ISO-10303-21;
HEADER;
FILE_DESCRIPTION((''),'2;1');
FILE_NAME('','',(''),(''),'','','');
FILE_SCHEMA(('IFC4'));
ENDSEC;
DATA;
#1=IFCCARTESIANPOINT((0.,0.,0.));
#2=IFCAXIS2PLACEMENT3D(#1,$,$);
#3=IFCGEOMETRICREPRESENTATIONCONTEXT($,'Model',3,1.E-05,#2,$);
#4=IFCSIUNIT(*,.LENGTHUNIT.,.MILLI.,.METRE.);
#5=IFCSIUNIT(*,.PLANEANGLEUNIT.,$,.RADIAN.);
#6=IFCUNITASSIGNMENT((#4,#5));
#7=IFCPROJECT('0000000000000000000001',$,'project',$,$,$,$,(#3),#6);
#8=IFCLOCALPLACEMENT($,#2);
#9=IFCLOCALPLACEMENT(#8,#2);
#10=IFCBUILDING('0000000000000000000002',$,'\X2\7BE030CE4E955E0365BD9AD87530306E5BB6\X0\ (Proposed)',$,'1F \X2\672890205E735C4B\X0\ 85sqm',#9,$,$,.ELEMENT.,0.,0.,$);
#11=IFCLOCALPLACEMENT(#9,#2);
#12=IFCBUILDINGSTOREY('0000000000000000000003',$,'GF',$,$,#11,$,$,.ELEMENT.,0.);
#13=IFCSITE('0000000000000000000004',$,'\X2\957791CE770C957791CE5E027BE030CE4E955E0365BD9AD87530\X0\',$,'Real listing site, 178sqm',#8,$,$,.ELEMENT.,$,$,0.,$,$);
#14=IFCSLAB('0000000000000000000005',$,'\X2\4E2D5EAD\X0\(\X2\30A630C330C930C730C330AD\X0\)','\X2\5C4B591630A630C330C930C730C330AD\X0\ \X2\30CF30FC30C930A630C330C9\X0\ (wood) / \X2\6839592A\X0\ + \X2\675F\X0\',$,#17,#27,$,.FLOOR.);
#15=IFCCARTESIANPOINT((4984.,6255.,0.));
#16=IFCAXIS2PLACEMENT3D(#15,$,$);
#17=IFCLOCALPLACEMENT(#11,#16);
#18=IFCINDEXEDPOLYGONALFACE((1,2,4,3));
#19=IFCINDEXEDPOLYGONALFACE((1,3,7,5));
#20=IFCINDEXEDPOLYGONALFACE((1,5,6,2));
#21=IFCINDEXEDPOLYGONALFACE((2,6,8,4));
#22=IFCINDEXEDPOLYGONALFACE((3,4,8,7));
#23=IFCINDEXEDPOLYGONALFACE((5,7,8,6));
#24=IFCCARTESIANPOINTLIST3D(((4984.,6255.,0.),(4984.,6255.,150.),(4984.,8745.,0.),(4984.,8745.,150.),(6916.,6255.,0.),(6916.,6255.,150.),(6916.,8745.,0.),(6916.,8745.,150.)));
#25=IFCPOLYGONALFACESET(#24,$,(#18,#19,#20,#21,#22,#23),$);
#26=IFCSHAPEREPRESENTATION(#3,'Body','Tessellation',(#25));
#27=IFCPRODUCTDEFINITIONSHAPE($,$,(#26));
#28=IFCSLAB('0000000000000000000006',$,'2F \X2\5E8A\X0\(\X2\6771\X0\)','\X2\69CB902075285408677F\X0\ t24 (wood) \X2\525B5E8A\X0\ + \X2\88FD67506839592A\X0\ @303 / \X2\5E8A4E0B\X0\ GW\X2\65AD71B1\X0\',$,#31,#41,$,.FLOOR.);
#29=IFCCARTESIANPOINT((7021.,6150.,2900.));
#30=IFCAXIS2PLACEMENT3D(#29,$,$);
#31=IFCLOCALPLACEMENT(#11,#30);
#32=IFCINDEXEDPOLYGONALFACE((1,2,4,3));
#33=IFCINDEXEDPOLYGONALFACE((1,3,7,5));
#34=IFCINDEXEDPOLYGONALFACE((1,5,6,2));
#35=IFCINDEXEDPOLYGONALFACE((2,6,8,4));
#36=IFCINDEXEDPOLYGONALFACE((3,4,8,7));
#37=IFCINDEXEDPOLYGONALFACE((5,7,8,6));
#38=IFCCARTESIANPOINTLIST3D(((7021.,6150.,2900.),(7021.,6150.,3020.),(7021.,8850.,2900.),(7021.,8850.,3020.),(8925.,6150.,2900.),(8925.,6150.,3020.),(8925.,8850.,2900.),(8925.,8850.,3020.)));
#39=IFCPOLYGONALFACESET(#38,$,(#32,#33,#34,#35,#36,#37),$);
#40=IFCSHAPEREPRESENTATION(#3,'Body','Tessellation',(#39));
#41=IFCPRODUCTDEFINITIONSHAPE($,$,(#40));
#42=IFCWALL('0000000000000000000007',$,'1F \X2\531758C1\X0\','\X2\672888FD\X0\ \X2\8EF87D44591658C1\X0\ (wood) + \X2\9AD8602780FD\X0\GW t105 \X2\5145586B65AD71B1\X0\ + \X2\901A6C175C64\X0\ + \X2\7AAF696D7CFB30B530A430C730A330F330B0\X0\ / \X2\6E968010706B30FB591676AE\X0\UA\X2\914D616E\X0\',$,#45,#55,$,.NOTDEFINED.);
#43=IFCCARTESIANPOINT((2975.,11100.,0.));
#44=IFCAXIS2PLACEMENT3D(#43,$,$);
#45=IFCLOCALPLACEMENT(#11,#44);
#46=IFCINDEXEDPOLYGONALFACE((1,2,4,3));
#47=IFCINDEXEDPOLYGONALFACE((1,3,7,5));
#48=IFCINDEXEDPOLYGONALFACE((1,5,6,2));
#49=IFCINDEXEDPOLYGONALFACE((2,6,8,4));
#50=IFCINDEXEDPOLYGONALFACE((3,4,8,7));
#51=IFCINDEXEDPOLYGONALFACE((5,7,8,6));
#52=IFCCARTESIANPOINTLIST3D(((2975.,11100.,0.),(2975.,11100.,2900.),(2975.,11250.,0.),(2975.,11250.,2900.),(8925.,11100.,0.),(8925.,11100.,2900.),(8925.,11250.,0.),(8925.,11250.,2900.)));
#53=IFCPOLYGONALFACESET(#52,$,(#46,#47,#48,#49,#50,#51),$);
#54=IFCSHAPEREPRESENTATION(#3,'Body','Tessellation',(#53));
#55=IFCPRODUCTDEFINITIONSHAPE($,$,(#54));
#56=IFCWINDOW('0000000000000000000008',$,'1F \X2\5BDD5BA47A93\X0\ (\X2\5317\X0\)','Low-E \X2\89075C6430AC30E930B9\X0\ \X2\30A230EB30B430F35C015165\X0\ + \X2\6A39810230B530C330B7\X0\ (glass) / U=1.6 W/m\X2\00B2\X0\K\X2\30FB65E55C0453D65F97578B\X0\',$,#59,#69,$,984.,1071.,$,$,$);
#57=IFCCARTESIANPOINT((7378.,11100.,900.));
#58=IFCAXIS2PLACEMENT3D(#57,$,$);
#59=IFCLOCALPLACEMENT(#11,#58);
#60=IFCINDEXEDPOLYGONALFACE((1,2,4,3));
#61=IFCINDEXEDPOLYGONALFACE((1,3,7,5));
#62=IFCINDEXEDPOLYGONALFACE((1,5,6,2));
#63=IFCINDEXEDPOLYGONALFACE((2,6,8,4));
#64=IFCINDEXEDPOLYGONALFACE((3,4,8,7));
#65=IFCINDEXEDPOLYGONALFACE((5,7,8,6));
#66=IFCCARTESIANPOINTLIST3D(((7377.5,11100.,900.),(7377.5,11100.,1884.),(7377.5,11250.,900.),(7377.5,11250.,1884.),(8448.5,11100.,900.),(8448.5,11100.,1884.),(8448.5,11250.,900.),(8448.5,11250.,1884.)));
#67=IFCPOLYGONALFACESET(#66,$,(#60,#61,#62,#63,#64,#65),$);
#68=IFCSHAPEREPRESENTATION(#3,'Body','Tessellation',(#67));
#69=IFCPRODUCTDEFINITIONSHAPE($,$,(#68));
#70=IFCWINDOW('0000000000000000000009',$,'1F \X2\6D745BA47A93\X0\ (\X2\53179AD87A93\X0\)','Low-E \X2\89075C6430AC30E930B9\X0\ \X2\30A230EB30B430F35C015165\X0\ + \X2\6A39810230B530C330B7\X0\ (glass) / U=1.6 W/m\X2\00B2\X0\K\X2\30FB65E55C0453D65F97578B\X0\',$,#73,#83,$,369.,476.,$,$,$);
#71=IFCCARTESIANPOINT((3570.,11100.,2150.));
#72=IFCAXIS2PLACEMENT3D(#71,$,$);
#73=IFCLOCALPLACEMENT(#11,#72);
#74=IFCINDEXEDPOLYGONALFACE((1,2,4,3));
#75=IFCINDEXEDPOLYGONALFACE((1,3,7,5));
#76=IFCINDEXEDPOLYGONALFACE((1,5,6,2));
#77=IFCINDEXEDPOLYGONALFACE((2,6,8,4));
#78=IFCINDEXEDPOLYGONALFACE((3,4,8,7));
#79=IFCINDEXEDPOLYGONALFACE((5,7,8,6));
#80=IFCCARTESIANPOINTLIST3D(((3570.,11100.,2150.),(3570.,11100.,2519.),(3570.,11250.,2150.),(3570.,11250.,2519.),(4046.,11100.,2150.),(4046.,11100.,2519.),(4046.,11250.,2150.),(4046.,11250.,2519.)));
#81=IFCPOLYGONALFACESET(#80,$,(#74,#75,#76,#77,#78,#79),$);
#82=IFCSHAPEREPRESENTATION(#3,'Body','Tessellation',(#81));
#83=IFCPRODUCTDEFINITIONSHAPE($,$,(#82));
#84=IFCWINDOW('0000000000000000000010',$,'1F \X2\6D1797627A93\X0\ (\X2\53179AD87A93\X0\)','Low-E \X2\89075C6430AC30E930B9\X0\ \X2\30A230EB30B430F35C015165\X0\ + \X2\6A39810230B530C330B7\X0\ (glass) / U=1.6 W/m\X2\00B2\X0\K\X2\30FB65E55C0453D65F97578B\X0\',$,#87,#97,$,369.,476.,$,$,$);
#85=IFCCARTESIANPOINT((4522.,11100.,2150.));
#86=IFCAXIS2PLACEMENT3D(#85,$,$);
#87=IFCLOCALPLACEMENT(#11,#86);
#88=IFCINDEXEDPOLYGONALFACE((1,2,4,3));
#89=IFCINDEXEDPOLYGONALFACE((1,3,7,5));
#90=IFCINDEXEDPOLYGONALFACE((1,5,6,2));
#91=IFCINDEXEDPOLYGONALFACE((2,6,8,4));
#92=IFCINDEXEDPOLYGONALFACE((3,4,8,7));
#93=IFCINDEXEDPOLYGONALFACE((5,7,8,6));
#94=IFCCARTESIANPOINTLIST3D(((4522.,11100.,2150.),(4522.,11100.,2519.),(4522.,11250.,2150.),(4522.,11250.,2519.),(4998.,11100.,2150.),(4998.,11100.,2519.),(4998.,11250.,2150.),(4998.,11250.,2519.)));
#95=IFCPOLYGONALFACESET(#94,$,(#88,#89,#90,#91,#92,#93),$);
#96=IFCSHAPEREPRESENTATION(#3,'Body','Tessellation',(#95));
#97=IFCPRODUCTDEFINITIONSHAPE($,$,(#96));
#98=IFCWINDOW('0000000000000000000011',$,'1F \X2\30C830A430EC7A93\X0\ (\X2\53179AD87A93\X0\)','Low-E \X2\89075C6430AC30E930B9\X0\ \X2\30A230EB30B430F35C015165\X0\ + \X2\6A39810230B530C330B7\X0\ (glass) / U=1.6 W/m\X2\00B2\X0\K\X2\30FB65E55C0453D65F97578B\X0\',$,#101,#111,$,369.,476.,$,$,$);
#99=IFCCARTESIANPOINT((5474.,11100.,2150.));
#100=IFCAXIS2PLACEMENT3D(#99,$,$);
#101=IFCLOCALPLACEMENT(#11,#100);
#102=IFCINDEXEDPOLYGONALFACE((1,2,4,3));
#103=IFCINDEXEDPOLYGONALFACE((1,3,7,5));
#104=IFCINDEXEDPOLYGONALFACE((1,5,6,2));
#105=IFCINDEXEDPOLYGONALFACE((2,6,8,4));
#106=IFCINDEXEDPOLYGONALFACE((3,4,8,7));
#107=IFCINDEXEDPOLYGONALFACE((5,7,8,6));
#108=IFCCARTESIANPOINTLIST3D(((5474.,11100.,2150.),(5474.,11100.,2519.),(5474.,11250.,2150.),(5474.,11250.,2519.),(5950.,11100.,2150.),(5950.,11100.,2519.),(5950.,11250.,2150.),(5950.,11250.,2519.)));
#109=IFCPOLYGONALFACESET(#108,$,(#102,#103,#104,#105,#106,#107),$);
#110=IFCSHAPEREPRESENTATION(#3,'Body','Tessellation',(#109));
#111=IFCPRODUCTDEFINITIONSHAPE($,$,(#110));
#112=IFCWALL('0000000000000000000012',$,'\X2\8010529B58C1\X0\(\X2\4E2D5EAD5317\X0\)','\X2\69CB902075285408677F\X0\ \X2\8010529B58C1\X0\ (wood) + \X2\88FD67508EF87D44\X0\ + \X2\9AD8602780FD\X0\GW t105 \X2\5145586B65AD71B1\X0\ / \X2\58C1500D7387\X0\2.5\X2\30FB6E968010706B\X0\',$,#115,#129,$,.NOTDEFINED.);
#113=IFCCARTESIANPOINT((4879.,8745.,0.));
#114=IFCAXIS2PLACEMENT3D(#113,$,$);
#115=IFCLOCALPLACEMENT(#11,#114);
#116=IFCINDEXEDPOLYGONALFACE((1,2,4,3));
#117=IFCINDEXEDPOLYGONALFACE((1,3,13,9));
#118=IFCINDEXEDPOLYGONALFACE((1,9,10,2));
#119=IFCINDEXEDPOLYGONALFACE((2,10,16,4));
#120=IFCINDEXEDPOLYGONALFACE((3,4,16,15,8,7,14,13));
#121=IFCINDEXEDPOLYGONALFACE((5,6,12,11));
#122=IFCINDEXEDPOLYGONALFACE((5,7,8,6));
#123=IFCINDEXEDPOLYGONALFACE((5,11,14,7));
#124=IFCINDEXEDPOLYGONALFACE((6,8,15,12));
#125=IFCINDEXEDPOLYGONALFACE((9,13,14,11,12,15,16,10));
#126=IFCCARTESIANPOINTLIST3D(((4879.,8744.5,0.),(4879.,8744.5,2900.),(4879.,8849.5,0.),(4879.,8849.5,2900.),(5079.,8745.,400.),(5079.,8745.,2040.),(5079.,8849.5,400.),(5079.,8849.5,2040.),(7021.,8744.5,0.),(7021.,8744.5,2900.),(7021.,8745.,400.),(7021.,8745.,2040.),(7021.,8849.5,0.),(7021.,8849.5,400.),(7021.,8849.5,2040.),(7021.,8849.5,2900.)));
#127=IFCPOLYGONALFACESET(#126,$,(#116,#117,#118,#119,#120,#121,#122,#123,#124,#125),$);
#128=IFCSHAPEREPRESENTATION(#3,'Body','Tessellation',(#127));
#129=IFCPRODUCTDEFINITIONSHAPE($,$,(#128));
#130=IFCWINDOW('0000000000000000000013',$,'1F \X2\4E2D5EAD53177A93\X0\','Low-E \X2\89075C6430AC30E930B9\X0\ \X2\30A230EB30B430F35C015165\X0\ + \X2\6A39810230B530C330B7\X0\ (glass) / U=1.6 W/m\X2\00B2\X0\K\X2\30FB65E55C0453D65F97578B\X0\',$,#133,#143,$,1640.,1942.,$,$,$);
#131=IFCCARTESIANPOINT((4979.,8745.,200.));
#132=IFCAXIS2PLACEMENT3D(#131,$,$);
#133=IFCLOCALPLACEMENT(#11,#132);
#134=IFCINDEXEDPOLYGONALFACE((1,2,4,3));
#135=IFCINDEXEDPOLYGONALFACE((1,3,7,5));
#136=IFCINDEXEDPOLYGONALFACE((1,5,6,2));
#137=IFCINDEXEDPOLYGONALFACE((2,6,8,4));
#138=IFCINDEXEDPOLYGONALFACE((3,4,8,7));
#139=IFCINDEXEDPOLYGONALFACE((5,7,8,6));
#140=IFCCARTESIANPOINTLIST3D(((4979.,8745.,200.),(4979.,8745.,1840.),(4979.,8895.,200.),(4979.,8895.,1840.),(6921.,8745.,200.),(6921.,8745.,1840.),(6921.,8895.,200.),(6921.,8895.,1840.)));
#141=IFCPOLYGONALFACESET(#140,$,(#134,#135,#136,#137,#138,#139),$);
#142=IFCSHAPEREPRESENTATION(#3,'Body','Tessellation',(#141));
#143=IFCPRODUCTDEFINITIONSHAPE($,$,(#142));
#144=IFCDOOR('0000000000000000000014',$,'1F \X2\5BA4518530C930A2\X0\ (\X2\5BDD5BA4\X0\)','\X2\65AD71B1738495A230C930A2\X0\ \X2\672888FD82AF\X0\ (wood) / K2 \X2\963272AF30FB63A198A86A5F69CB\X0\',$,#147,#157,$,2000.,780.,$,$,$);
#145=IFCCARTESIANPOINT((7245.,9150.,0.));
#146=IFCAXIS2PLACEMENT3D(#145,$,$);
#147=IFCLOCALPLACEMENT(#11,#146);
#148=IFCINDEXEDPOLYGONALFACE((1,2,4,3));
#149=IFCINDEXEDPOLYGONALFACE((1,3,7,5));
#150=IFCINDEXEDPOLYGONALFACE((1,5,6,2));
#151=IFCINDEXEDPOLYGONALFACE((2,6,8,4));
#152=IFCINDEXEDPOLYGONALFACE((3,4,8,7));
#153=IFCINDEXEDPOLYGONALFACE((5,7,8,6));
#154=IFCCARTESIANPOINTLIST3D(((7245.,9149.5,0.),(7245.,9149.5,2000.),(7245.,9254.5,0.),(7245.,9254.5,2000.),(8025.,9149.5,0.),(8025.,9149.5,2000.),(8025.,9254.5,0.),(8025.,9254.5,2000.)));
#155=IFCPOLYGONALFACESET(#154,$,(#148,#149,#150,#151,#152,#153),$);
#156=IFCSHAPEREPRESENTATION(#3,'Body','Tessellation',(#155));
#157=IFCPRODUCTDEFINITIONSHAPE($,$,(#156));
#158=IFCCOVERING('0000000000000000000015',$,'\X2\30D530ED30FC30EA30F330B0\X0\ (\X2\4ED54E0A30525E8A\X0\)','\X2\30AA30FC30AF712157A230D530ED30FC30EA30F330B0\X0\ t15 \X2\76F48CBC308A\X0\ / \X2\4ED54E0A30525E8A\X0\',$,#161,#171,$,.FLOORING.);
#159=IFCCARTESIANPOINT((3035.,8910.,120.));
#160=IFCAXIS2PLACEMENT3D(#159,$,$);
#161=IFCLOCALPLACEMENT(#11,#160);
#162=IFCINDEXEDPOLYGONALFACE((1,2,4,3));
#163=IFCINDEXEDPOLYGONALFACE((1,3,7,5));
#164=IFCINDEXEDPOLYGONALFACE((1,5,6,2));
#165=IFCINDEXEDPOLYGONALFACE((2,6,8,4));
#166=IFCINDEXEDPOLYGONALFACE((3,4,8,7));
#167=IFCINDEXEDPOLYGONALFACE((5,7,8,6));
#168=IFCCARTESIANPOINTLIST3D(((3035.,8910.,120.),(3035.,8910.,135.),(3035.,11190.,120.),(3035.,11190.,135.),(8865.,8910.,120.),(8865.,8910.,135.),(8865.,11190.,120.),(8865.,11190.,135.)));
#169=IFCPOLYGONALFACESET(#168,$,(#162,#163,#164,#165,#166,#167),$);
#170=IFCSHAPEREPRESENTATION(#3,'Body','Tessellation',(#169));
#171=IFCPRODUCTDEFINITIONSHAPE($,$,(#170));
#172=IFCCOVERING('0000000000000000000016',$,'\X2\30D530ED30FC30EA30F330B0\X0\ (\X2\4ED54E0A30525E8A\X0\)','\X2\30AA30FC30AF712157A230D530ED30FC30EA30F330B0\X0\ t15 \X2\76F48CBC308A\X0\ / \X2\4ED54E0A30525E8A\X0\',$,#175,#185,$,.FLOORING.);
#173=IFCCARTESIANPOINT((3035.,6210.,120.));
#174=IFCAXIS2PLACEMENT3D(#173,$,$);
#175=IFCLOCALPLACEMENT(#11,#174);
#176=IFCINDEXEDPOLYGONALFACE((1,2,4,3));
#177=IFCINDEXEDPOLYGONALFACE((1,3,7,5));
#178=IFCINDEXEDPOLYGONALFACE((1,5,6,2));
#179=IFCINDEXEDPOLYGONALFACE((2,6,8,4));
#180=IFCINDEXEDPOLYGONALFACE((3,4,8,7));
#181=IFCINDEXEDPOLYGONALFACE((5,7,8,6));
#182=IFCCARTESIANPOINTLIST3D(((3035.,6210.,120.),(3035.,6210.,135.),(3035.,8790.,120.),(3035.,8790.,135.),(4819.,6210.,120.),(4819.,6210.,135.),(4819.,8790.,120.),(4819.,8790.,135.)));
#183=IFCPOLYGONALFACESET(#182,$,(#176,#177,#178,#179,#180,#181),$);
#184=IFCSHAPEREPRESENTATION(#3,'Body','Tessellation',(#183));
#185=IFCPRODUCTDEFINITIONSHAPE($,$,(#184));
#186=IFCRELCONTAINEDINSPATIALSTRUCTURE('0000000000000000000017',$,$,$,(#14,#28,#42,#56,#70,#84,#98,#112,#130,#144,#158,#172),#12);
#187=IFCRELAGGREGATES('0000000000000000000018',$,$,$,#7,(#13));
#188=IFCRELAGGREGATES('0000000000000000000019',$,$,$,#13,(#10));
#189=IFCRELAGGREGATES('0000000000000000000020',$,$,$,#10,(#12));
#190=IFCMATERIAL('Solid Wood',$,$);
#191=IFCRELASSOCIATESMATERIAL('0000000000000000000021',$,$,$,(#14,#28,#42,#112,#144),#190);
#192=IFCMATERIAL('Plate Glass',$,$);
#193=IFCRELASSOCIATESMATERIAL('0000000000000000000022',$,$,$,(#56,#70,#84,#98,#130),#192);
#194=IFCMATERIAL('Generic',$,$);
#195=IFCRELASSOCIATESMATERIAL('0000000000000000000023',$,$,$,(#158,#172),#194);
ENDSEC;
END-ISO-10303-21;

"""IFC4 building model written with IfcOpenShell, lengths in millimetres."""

from ifc_helpers import new_model, si_unit, frame, frame_2d, origin, place, context, project, spatial, rectangle, extrude, material, element, fill, save


model = new_model("IFC4")

# Units and contexts
model_context = context("Model", 3, precision=1e-05, world=origin())
ifc_project = project(units=[si_unit("LENGTHUNIT", "METRE", prefix="MILLI"), si_unit("PLANEANGLEUNIT", "RADIAN")], contexts=[model_context])

# Site, building, storey
site_placement = place(None, origin())
site = spatial("IfcSite", under=ifc_project, at=site_placement, Name="長野県長野市篠ノ井布施高田", ObjectType="Real listing site, 178sqm", CompositionType="ELEMENT", RefElevation=0.0)
building_placement = place(site_placement, origin())
building = spatial("IfcBuilding", under=site, at=building_placement, Name="篠ノ井布施高田の家 (Proposed)", ObjectType="1F 木造平屋 85sqm", CompositionType="ELEMENT", ElevationOfRefHeight=0.0, ElevationOfTerrain=0.0)
storey_placement = place(building_placement, origin())
storey = spatial("IfcBuildingStorey", under=building, at=storey_placement, Name="GF", CompositionType="ELEMENT", Elevation=0.0)

# Slabs
ifc_material_1 = material(Name="Solid Wood")
slab_1_placement = place(storey_placement, frame((4984.0, 6255.0, 0.0)))
element("IfcSlab", 1, at=slab_1_placement, inside=storey, material=ifc_material_1, Name="中庭(ウッドデッキ)", Description="屋外ウッドデッキ ハードウッド (wood) / 根太 + 束", PredefinedType="FLOOR", context=model_context, shape_type="SweptSolid", body=[
    extrude(rectangle(XDim=1932.0, YDim=2490.0, at=frame_2d((966.0, 1245.0))), frame((4984.0, 6255.0, 0.0)), (0.0, 0.0, 1.0), 150.0),
])
slab_2_placement = place(storey_placement, frame((7021.0, 6150.0, 2900.0)))
element("IfcSlab", 2, at=slab_2_placement, inside=storey, material=ifc_material_1, Name="2F 床(東)", Description="構造用合板 t24 (wood) 剛床 + 製材根太 @303 / 床下 GW断熱", PredefinedType="FLOOR", context=model_context, shape_type="SweptSolid", body=[
    extrude(rectangle(XDim=1904.0, YDim=2700.0, at=frame_2d((952.0, 1350.0))), frame((7021.0, 6150.0, 2900.0)), (0.0, 0.0, 1.0), 120.0),
])

# Wall, openings, windows
wall_1_placement = place(storey_placement, frame((2975.0, 11100.0, 0.0)))
wall_1 = element("IfcWall", 3, at=wall_1_placement, inside=storey, material=ifc_material_1, Name="1F 北壁", Description="木製 軸組外壁 (wood) + 高性能GW t105 充填断熱 + 通気層 + 窯業系サイディング / 準耐火・外皮UA配慮", PredefinedType="NOTDEFINED", context=model_context, shape_type="SweptSolid", body=[
    extrude(rectangle(XDim=5950.0, YDim=150.0, at=frame_2d((2975.0, 75.0))), frame((2975.0, 11100.0, 0.0)), (0.0, 0.0, 1.0), 2900.0),
])
opening_1_placement = place(storey_placement, frame((7378.0, 11100.0, 900.0)))
opening_1 = element("IfcOpeningElement", 4, at=opening_1_placement, cuts=wall_1, PredefinedType="NOTDEFINED", context=model_context, shape_type="SweptSolid", body=[
    extrude(rectangle(XDim=1071.0, YDim=150.0, at=frame_2d((535.0, 75.0))), frame((7378.0, 11100.0, 900.0)), (0.0, 0.0, 1.0), 984.0),
])
opening_2_placement = place(storey_placement, frame((3570.0, 11100.0, 2150.0)))
opening_2 = element("IfcOpeningElement", 5, at=opening_2_placement, cuts=wall_1, PredefinedType="NOTDEFINED", context=model_context, shape_type="SweptSolid", body=[
    extrude(rectangle(XDim=476.0, YDim=150.0, at=frame_2d((238.0, 75.0))), frame((3570.0, 11100.0, 2150.0)), (0.0, 0.0, 1.0), 369.0),
])
opening_3_placement = place(storey_placement, frame((4522.0, 11100.0, 2150.0)))
opening_3 = element("IfcOpeningElement", 6, at=opening_3_placement, cuts=wall_1, PredefinedType="NOTDEFINED", context=model_context, shape_type="SweptSolid", body=[
    extrude(rectangle(XDim=476.0, YDim=150.0, at=frame_2d((238.0, 75.0))), frame((4522.0, 11100.0, 2150.0)), (0.0, 0.0, 1.0), 369.0),
])
opening_4_placement = place(storey_placement, frame((5474.0, 11100.0, 2150.0)))
opening_4 = element("IfcOpeningElement", 7, at=opening_4_placement, cuts=wall_1, PredefinedType="NOTDEFINED", context=model_context, shape_type="SweptSolid", body=[
    extrude(rectangle(XDim=476.0, YDim=150.0, at=frame_2d((238.0, 75.0))), frame((5474.0, 11100.0, 2150.0)), (0.0, 0.0, 1.0), 369.0),
])
ifc_material_2 = material(Name="Plate Glass")
window_1_placement = place(storey_placement, frame((7378.0, 11100.0, 900.0)))
window_1 = element("IfcWindow", 8, at=window_1_placement, inside=storey, material=ifc_material_2, Name="1F 寝室窓 (北)", Description="Low-E 複層ガラス アルゴン封入 + 樹脂サッシ (glass) / U=1.6 W/m²K・日射取得型", OverallHeight=984.0, OverallWidth=1071.0, context=model_context, shape_type="SweptSolid", body=[
    extrude(rectangle(XDim=1071.0, YDim=150.0, at=frame_2d((535.0, 75.0))), frame((7378.0, 11100.0, 900.0)), (0.0, 0.0, 1.0), 984.0),
])
fill(opening_1, window_1)
window_2_placement = place(storey_placement, frame((3570.0, 11100.0, 2150.0)))
window_2 = element("IfcWindow", 9, at=window_2_placement, inside=storey, material=ifc_material_2, Name="1F 浴室窓 (北高窓)", Description="Low-E 複層ガラス アルゴン封入 + 樹脂サッシ (glass) / U=1.6 W/m²K・日射取得型", OverallHeight=369.0, OverallWidth=476.0, context=model_context, shape_type="SweptSolid", body=[
    extrude(rectangle(XDim=476.0, YDim=150.0, at=frame_2d((238.0, 75.0))), frame((3570.0, 11100.0, 2150.0)), (0.0, 0.0, 1.0), 369.0),
])
fill(opening_2, window_2)
window_3_placement = place(storey_placement, frame((4522.0, 11100.0, 2150.0)))
window_3 = element("IfcWindow", 10, at=window_3_placement, inside=storey, material=ifc_material_2, Name="1F 洗面窓 (北高窓)", Description="Low-E 複層ガラス アルゴン封入 + 樹脂サッシ (glass) / U=1.6 W/m²K・日射取得型", OverallHeight=369.0, OverallWidth=476.0, context=model_context, shape_type="SweptSolid", body=[
    extrude(rectangle(XDim=476.0, YDim=150.0, at=frame_2d((238.0, 75.0))), frame((4522.0, 11100.0, 2150.0)), (0.0, 0.0, 1.0), 369.0),
])
fill(opening_3, window_3)
window_4_placement = place(storey_placement, frame((5474.0, 11100.0, 2150.0)))
window_4 = element("IfcWindow", 11, at=window_4_placement, inside=storey, material=ifc_material_2, Name="1F トイレ窓 (北高窓)", Description="Low-E 複層ガラス アルゴン封入 + 樹脂サッシ (glass) / U=1.6 W/m²K・日射取得型", OverallHeight=369.0, OverallWidth=476.0, context=model_context, shape_type="SweptSolid", body=[
    extrude(rectangle(XDim=476.0, YDim=150.0, at=frame_2d((238.0, 75.0))), frame((5474.0, 11100.0, 2150.0)), (0.0, 0.0, 1.0), 369.0),
])
fill(opening_4, window_4)

# Wall, opening, window
wall_2_placement = place(storey_placement, frame((4879.0, 8745.0, 0.0)))
wall_2 = element("IfcWall", 12, at=wall_2_placement, inside=storey, material=ifc_material_1, Name="耐力壁(中庭北)", Description="構造用合板 耐力壁 (wood) + 製材軸組 + 高性能GW t105 充填断熱 / 壁倍率2.5・準耐火", PredefinedType="NOTDEFINED", context=model_context, shape_type="SweptSolid", body=[
    extrude(rectangle(XDim=2142.0, YDim=105.0, at=frame_2d((1071.0, 52.0))), frame((4879.0, 8745.0, 0.0)), (0.0, 0.0, 1.0), 2900.0),
])
opening_5_placement = place(storey_placement, frame((4979.0, 8745.0, 200.0)))
opening_5 = element("IfcOpeningElement", 13, at=opening_5_placement, cuts=wall_2, PredefinedType="NOTDEFINED", context=model_context, shape_type="SweptSolid", body=[
    extrude(rectangle(XDim=1942.0, YDim=150.0, at=frame_2d((971.0, 75.0))), frame((4979.0, 8745.0, 200.0)), (0.0, 0.0, 1.0), 1640.0),
])
window_5_placement = place(storey_placement, frame((4979.0, 8745.0, 200.0)))
window_5 = element("IfcWindow", 14, at=window_5_placement, inside=storey, material=ifc_material_2, Name="1F 中庭北窓", Description="Low-E 複層ガラス アルゴン封入 + 樹脂サッシ (glass) / U=1.6 W/m²K・日射取得型", OverallHeight=1640.0, OverallWidth=1942.0, context=model_context, shape_type="SweptSolid", body=[
    extrude(rectangle(XDim=1942.0, YDim=150.0, at=frame_2d((971.0, 75.0))), frame((4979.0, 8745.0, 200.0)), (0.0, 0.0, 1.0), 1640.0),
])
fill(opening_5, window_5)

# Door
door_1_placement = place(storey_placement, frame((7245.0, 9150.0, 0.0)))
element("IfcDoor", 15, at=door_1_placement, inside=storey, material=ifc_material_1, Name="1F 室内ドア (寝室)", Description="断熱玄関ドア 木製芯 (wood) / K2 防犯・採風機構", OverallHeight=2000.0, OverallWidth=780.0, context=model_context, shape_type="SweptSolid", body=[
    extrude(rectangle(XDim=780.0, YDim=105.0, at=frame_2d((390.0, 52.0))), frame((7245.0, 9150.0, 0.0)), (0.0, 0.0, 1.0), 2000.0),
])

# Coverings
ifc_material_3 = material(Name="Generic")
covering_1_placement = place(storey_placement, frame((3035.0, 8910.0, 120.0)))
element("IfcCovering", 16, at=covering_1_placement, inside=storey, material=ifc_material_3, Name="フローリング (仕上げ床)", Description="オーク無垢フローリング t15 直貼り / 仕上げ床", PredefinedType="FLOORING", context=model_context, shape_type="SweptSolid", body=[
    extrude(rectangle(XDim=5830.0, YDim=2280.0, at=frame_2d((2915.0, 1140.0))), frame((3035.0, 8910.0, 120.0)), (0.0, 0.0, 1.0), 15.0),
])
covering_2_placement = place(storey_placement, frame((3035.0, 6210.0, 120.0)))
element("IfcCovering", 17, at=covering_2_placement, inside=storey, material=ifc_material_3, Name="フローリング (仕上げ床)", Description="オーク無垢フローリング t15 直貼り / 仕上げ床", PredefinedType="FLOORING", context=model_context, shape_type="SweptSolid", body=[
    extrude(rectangle(XDim=1784.0, YDim=2580.0, at=frame_2d((892.0, 1290.0))), frame((3035.0, 6210.0, 120.0)), (0.0, 0.0, 1.0), 15.0),
])

save(model, "model.ifc")
